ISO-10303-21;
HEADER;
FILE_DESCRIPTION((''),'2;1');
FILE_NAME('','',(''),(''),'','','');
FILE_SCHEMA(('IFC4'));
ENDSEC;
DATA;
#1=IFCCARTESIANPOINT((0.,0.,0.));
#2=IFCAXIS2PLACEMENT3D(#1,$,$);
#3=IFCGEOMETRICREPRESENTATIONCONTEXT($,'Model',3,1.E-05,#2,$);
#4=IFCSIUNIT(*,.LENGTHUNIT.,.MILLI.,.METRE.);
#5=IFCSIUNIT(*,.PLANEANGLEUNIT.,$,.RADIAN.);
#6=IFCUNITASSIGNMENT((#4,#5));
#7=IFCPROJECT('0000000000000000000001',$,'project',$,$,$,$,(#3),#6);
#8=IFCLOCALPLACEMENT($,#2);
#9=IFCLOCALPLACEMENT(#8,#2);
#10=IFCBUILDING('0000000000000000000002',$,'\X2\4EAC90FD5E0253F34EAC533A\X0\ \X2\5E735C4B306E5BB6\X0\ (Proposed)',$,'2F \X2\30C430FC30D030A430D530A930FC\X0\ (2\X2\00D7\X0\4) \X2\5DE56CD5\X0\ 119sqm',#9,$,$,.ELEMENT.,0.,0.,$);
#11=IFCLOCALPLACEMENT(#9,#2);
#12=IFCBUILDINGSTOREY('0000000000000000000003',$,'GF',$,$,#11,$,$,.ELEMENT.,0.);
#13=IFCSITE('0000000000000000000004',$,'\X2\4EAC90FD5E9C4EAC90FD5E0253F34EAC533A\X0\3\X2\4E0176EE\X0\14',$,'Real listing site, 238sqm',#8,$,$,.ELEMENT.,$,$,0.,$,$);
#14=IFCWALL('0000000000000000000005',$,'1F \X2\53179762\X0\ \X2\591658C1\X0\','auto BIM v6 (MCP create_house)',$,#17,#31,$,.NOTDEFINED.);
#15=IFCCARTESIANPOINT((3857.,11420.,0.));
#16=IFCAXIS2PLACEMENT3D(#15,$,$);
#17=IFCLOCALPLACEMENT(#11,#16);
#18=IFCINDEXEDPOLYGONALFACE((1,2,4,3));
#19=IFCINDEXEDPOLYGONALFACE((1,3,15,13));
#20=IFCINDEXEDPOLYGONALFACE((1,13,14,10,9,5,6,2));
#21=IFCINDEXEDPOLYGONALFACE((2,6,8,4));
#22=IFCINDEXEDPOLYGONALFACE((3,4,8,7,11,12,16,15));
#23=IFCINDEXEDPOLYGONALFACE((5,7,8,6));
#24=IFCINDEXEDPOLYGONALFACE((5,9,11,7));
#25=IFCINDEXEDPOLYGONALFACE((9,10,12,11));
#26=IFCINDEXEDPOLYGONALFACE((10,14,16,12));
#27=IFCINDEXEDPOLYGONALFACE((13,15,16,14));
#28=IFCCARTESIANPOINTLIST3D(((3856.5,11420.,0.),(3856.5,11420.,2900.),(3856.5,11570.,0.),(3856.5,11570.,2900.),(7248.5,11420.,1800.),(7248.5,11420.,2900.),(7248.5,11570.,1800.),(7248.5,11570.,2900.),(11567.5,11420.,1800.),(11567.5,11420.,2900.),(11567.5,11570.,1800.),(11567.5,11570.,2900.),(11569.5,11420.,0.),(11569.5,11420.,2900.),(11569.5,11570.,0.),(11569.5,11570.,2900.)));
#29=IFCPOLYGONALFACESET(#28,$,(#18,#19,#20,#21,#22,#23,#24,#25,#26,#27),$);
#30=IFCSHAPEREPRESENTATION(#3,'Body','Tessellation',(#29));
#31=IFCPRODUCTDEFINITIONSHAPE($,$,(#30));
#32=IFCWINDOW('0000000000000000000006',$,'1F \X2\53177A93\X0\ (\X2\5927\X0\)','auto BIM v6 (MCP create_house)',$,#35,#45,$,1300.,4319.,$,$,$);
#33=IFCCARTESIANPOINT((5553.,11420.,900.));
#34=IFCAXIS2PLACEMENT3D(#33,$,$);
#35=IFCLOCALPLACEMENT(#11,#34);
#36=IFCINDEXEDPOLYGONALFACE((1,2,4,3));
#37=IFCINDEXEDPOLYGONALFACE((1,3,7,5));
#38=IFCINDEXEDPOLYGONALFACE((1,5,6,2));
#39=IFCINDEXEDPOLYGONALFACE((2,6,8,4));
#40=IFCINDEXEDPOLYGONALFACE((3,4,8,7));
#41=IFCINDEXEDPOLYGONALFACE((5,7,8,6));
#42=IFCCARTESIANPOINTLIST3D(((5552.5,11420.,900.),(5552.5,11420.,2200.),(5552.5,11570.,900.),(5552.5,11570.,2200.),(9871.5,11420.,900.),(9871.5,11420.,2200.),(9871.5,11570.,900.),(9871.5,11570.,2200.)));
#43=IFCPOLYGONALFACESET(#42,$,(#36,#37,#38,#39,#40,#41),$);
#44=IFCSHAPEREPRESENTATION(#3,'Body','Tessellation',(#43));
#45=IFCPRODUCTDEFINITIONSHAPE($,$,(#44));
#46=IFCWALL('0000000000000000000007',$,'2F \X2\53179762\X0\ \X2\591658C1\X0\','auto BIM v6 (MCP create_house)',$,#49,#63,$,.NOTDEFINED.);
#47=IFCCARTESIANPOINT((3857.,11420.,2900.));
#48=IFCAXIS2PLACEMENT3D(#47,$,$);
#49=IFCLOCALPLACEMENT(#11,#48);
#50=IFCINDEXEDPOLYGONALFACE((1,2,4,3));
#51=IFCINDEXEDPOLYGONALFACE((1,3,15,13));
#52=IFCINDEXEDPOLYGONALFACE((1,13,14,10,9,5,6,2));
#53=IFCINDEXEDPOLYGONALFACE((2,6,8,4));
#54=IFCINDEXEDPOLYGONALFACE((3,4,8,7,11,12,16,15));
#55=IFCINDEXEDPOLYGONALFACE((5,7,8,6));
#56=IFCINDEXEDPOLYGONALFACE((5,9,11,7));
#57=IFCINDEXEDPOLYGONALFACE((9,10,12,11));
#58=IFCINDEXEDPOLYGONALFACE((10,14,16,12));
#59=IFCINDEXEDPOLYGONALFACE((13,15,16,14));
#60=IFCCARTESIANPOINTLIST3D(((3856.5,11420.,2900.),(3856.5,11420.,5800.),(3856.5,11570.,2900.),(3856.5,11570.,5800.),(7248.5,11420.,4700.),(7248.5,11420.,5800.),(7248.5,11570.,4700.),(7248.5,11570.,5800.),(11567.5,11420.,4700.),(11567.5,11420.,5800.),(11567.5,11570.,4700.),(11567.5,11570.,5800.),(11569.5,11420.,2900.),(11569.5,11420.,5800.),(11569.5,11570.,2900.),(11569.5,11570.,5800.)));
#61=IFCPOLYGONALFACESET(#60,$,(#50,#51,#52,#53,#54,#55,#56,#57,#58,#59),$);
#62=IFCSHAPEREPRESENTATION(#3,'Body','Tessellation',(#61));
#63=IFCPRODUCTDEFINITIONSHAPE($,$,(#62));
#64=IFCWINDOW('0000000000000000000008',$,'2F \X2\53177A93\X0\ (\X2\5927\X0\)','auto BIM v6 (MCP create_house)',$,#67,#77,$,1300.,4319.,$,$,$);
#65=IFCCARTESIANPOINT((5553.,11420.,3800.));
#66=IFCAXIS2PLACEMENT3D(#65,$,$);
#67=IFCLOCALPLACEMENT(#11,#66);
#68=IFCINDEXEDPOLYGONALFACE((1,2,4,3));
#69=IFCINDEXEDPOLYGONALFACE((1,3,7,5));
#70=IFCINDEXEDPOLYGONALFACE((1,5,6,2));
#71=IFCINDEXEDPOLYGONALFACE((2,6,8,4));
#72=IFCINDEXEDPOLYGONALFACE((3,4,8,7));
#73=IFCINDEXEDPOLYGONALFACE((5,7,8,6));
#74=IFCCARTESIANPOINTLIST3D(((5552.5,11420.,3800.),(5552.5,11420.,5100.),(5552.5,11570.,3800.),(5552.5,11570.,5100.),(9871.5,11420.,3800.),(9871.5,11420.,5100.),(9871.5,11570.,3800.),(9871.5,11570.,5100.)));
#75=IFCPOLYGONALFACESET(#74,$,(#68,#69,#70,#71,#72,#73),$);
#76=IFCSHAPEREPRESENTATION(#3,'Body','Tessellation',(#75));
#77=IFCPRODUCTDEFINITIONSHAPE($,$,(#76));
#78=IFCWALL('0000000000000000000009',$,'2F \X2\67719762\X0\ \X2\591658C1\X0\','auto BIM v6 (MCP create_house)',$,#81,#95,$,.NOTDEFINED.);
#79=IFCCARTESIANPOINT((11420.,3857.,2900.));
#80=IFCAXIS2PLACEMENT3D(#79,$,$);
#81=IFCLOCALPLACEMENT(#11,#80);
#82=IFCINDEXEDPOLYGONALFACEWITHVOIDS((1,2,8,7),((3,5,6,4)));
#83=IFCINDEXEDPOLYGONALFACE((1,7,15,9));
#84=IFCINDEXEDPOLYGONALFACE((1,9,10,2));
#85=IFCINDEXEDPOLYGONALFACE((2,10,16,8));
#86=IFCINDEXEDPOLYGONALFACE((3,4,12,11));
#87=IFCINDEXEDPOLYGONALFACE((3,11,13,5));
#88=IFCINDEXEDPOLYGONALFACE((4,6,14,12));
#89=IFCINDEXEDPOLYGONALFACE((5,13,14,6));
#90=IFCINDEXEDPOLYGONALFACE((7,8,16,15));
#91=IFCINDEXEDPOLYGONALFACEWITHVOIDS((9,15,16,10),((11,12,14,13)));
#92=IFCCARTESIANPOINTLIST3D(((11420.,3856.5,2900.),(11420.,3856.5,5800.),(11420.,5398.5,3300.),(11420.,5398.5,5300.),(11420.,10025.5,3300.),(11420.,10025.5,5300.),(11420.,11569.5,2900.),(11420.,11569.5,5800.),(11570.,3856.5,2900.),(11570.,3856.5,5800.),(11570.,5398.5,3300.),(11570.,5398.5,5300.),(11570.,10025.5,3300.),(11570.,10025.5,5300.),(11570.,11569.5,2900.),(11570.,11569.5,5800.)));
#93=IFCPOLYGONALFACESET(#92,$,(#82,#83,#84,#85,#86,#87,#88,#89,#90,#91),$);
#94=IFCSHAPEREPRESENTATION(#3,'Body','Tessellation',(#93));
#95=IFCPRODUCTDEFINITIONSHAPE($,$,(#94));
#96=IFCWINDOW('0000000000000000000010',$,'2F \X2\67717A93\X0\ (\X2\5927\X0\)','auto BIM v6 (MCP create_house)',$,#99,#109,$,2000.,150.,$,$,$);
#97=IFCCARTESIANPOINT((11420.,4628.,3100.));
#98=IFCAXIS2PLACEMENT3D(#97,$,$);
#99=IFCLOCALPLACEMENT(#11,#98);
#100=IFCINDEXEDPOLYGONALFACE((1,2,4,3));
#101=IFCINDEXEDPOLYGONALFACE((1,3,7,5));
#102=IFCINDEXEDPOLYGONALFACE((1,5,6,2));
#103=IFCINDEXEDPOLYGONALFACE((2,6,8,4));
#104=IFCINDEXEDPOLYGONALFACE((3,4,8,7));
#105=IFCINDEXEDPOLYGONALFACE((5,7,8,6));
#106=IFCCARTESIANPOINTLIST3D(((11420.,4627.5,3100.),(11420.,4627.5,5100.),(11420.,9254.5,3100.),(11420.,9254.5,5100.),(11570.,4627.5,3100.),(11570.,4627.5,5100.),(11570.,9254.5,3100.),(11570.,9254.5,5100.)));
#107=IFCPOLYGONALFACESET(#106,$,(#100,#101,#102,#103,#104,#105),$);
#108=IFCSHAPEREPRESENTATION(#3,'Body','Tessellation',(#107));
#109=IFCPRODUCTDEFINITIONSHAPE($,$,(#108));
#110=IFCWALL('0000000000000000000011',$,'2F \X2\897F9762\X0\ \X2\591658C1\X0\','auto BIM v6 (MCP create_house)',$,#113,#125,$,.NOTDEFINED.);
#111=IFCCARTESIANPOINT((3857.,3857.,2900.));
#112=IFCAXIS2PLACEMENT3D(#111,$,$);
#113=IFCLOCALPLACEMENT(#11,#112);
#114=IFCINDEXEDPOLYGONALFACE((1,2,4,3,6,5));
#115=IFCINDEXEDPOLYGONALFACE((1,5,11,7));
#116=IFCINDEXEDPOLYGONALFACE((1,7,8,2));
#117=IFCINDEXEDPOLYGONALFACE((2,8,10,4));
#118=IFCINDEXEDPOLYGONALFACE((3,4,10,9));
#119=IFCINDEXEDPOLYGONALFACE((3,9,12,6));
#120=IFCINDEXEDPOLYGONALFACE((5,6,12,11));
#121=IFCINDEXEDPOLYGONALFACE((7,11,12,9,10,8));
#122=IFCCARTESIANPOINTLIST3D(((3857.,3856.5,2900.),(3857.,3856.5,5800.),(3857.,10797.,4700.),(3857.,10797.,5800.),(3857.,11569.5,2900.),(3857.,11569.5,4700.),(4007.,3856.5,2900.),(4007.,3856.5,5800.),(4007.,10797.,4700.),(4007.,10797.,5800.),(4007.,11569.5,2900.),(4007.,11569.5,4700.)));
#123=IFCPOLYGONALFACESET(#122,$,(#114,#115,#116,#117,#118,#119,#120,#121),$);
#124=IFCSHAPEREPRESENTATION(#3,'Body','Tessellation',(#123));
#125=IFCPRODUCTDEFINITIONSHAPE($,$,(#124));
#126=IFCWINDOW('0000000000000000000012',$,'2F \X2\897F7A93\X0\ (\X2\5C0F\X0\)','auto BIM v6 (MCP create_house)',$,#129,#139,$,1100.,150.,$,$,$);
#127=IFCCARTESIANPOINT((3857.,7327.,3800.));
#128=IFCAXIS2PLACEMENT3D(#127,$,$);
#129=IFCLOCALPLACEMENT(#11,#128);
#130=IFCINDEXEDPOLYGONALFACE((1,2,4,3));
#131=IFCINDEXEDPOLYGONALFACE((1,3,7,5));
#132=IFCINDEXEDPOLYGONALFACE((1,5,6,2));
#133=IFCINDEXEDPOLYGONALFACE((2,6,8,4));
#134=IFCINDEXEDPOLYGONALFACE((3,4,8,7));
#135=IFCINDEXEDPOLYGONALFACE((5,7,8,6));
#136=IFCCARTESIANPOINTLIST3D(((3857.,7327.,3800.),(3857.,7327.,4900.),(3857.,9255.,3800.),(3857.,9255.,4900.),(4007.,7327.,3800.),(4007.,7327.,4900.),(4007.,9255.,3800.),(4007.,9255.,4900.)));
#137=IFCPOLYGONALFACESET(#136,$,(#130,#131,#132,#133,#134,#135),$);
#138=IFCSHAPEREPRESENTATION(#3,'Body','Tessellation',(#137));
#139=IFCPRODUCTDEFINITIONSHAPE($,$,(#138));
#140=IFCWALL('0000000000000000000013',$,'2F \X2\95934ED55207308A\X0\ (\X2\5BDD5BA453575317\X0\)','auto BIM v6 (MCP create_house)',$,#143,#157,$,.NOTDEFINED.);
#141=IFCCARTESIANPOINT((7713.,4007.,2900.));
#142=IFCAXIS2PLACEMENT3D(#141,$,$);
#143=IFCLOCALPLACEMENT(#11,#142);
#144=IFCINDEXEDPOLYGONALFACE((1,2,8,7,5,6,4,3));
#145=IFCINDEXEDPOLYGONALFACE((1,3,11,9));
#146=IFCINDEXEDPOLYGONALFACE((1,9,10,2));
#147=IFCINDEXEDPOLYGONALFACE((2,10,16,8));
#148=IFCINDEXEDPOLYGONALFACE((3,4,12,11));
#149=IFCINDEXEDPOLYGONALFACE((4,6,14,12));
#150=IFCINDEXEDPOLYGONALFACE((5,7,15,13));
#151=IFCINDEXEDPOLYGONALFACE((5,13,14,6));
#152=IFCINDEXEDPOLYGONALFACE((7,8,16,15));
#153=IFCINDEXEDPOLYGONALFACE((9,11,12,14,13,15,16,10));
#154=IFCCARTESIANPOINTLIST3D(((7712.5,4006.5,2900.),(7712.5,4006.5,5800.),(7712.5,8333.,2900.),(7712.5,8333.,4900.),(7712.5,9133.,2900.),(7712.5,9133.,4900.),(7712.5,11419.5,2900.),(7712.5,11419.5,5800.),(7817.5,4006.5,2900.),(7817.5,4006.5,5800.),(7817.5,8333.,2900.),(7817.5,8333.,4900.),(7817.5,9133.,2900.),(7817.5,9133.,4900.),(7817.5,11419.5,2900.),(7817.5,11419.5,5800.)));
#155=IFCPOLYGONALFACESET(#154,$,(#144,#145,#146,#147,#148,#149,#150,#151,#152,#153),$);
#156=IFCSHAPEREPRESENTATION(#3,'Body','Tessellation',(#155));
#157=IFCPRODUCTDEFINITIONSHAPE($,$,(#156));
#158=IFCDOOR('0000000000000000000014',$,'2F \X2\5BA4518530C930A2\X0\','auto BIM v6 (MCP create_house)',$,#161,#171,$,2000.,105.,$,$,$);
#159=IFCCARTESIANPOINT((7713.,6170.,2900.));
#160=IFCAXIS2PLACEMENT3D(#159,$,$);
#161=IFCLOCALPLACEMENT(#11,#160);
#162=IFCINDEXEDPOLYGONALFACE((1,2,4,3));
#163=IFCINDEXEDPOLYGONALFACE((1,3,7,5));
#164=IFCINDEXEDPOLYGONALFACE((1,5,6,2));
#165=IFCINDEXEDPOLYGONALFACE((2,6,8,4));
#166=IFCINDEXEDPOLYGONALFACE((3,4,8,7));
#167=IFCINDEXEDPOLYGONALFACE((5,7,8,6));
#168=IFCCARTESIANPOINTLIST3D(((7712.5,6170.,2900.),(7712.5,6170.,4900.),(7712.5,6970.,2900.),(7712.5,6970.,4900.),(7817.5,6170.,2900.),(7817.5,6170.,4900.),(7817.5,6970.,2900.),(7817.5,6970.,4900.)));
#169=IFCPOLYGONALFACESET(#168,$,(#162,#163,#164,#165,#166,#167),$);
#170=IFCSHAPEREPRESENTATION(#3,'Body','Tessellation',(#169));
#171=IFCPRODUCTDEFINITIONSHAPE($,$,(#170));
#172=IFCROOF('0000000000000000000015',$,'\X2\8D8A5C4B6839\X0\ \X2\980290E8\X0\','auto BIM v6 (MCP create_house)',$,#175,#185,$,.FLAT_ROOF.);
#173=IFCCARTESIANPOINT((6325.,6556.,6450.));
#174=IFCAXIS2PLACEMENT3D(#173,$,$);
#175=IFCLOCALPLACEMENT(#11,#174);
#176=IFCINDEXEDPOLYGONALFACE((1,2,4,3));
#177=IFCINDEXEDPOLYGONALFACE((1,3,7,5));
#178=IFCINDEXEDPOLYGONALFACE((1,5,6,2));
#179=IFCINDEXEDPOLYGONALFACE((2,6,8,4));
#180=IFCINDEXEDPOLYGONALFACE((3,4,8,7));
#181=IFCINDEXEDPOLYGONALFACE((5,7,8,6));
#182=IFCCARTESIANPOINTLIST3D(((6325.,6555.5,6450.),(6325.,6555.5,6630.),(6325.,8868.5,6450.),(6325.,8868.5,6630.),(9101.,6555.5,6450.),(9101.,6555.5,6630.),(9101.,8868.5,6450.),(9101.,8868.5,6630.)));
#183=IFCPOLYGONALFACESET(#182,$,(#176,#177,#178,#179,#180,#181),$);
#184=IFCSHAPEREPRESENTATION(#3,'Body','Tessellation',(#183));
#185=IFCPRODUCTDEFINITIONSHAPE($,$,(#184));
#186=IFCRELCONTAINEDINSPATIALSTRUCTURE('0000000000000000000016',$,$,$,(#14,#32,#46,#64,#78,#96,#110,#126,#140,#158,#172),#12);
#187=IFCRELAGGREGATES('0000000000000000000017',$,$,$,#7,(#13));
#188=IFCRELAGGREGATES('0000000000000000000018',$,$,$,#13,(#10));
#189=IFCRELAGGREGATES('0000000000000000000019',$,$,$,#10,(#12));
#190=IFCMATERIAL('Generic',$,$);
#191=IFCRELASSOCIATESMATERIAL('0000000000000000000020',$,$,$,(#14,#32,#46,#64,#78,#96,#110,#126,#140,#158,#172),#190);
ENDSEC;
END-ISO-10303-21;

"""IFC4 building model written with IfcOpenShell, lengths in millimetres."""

from ifc_helpers import new_model, si_unit, frame, frame_2d, origin, place, context, project, spatial, rectangle, extrude, material, element, fill, save


model = new_model("IFC4")

# Units and contexts
model_context = context("Model", 3, precision=1e-05, world=origin())
ifc_project = project(units=[si_unit("LENGTHUNIT", "METRE", prefix="MILLI"), si_unit("PLANEANGLEUNIT", "RADIAN")], contexts=[model_context])

# Site, building, storey
site_placement = place(None, origin())
site = spatial("IfcSite", under=ifc_project, at=site_placement, Name="京都府京都市右京区3丁目14", ObjectType="Real listing site, 238sqm", CompositionType="ELEMENT", RefElevation=0.0)
building_placement = place(site_placement, origin())
building = spatial("IfcBuilding", under=site, at=building_placement, Name="京都市右京区 平屋の家 (Proposed)", ObjectType="2F ツーバイフォー (2×4) 工法 119sqm", CompositionType="ELEMENT", ElevationOfRefHeight=0.0, ElevationOfTerrain=0.0)
storey_placement = place(building_placement, origin())
storey = spatial("IfcBuildingStorey", under=building, at=storey_placement, Name="GF", CompositionType="ELEMENT", Elevation=0.0)

# Wall, opening, window
ifc_material = material(Name="Generic")
wall_1_placement = place(storey_placement, frame((3857.0, 11420.0, 0.0)))
wall_1 = element("IfcWall", 1, at=wall_1_placement, inside=storey, material=ifc_material, Name="1F 北面 外壁", Description="auto BIM v6 (MCP create_house)", PredefinedType="NOTDEFINED", context=model_context, shape_type="SweptSolid", body=[
    extrude(rectangle(XDim=7713.0, YDim=150.0, at=frame_2d((3856.0, 75.0))), frame((3857.0, 11420.0, 0.0)), (0.0, 0.0, 1.0), 2900.0),
])
opening_1_placement = place(storey_placement, frame((5553.0, 11420.0, 900.0)))
opening_1 = element("IfcOpeningElement", 2, at=opening_1_placement, cuts=wall_1, PredefinedType="NOTDEFINED", context=model_context, shape_type="SweptSolid", body=[
    extrude(rectangle(XDim=4319.0, YDim=150.0, at=frame_2d((2159.0, 75.0))), frame((5553.0, 11420.0, 900.0)), (0.0, 0.0, 1.0), 1300.0),
])
window_1_placement = place(storey_placement, frame((5553.0, 11420.0, 900.0)))
window_1 = element("IfcWindow", 3, at=window_1_placement, inside=storey, material=ifc_material, Name="1F 北窓 (大)", Description="auto BIM v6 (MCP create_house)", OverallHeight=1300.0, OverallWidth=4319.0, context=model_context, shape_type="SweptSolid", body=[
    extrude(rectangle(XDim=4319.0, YDim=150.0, at=frame_2d((2159.0, 75.0))), frame((5553.0, 11420.0, 900.0)), (0.0, 0.0, 1.0), 1300.0),
])
fill(opening_1, window_1)

# Walls, openings, windows
wall_2_placement = place(storey_placement, frame((3857.0, 11420.0, 2900.0)))
wall_2 = element("IfcWall", 4, at=wall_2_placement, inside=storey, material=ifc_material, Name="2F 北面 外壁", Description="auto BIM v6 (MCP create_house)", PredefinedType="NOTDEFINED", context=model_context, shape_type="SweptSolid", body=[
    extrude(rectangle(XDim=7713.0, YDim=150.0, at=frame_2d((3856.0, 75.0))), frame((3857.0, 11420.0, 2900.0)), (0.0, 0.0, 1.0), 2900.0),
])
opening_2_placement = place(storey_placement, frame((5553.0, 11420.0, 3800.0)))
opening_2 = element("IfcOpeningElement", 5, at=opening_2_placement, cuts=wall_2, PredefinedType="NOTDEFINED", context=model_context, shape_type="SweptSolid", body=[
    extrude(rectangle(XDim=4319.0, YDim=150.0, at=frame_2d((2159.0, 75.0))), frame((5553.0, 11420.0, 3800.0)), (0.0, 0.0, 1.0), 1300.0),
])
window_2_placement = place(storey_placement, frame((5553.0, 11420.0, 3800.0)))
window_2 = element("IfcWindow", 6, at=window_2_placement, inside=storey, material=ifc_material, Name="2F 北窓 (大)", Description="auto BIM v6 (MCP create_house)", OverallHeight=1300.0, OverallWidth=4319.0, context=model_context, shape_type="SweptSolid", body=[
    extrude(rectangle(XDim=4319.0, YDim=150.0, at=frame_2d((2159.0, 75.0))), frame((5553.0, 11420.0, 3800.0)), (0.0, 0.0, 1.0), 1300.0),
])
fill(opening_2, window_2)
wall_3_placement = place(storey_placement, frame((11420.0, 3857.0, 2900.0)))
wall_3 = element("IfcWall", 7, at=wall_3_placement, inside=storey, material=ifc_material, Name="2F 東面 外壁", Description="auto BIM v6 (MCP create_house)", PredefinedType="NOTDEFINED", context=model_context, shape_type="SweptSolid", body=[
    extrude(rectangle(XDim=150.0, YDim=7713.0, at=frame_2d((75.0, 3856.0))), frame((11420.0, 3857.0, 2900.0)), (0.0, 0.0, 1.0), 2900.0),
])
opening_3_placement = place(storey_placement, frame((11420.0, 4628.0, 3100.0)))
opening_3 = element("IfcOpeningElement", 8, at=opening_3_placement, cuts=wall_3, PredefinedType="NOTDEFINED", context=model_context, shape_type="SweptSolid", body=[
    extrude(rectangle(XDim=150.0, YDim=4627.0, at=frame_2d((75.0, 2313.0))), frame((11420.0, 4628.0, 3100.0)), (0.0, 0.0, 1.0), 2000.0),
])
window_3_placement = place(storey_placement, frame((11420.0, 4628.0, 3100.0)))
window_3 = element("IfcWindow", 9, at=window_3_placement, inside=storey, material=ifc_material, Name="2F 東窓 (大)", Description="auto BIM v6 (MCP create_house)", OverallHeight=2000.0, OverallWidth=150.0, context=model_context, shape_type="SweptSolid", body=[
    extrude(rectangle(XDim=150.0, YDim=4627.0, at=frame_2d((75.0, 2313.0))), frame((11420.0, 4628.0, 3100.0)), (0.0, 0.0, 1.0), 2000.0),
])
fill(opening_3, window_3)
wall_4_placement = place(storey_placement, frame((3857.0, 3857.0, 2900.0)))
wall_4 = element("IfcWall", 10, at=wall_4_placement, inside=storey, material=ifc_material, Name="2F 西面 外壁", Description="auto BIM v6 (MCP create_house)", PredefinedType="NOTDEFINED", context=model_context, shape_type="SweptSolid", body=[
    extrude(rectangle(XDim=150.0, YDim=7713.0, at=frame_2d((75.0, 3856.0))), frame((3857.0, 3857.0, 2900.0)), (0.0, 0.0, 1.0), 2900.0),
])
opening_4_placement = place(storey_placement, frame((3857.0, 7327.0, 3800.0)))
opening_4 = element("IfcOpeningElement", 11, at=opening_4_placement, cuts=wall_4, PredefinedType="NOTDEFINED", context=model_context, shape_type="SweptSolid", body=[
    extrude(rectangle(XDim=150.0, YDim=1928.0, at=frame_2d((75.0, 964.0))), frame((3857.0, 7327.0, 3800.0)), (0.0, 0.0, 1.0), 1100.0),
])
window_4_placement = place(storey_placement, frame((3857.0, 7327.0, 3800.0)))
window_4 = element("IfcWindow", 12, at=window_4_placement, inside=storey, material=ifc_material, Name="2F 西窓 (小)", Description="auto BIM v6 (MCP create_house)", OverallHeight=1100.0, OverallWidth=150.0, context=model_context, shape_type="SweptSolid", body=[
    extrude(rectangle(XDim=150.0, YDim=1928.0, at=frame_2d((75.0, 964.0))), frame((3857.0, 7327.0, 3800.0)), (0.0, 0.0, 1.0), 1100.0),
])
fill(opening_4, window_4)

# Wall, opening, door
wall_5_placement = place(storey_placement, frame((7713.0, 4007.0, 2900.0)))
wall_5 = element("IfcWall", 13, at=wall_5_placement, inside=storey, material=ifc_material, Name="2F 間仕切り (寝室南北)", Description="auto BIM v6 (MCP create_house)", PredefinedType="NOTDEFINED", context=model_context, shape_type="SweptSolid", body=[
    extrude(rectangle(XDim=105.0, YDim=7413.0, at=frame_2d((52.0, 3706.0))), frame((7713.0, 4007.0, 2900.0)), (0.0, 0.0, 1.0), 2900.0),
])
opening_5_placement = place(storey_placement, frame((7713.0, 6170.0, 2900.0)))
opening_5 = element("IfcOpeningElement", 14, at=opening_5_placement, cuts=wall_5, PredefinedType="NOTDEFINED", context=model_context, shape_type="SweptSolid", body=[
    extrude(rectangle(XDim=105.0, YDim=800.0, at=frame_2d((52.0, 400.0))), frame((7713.0, 6170.0, 2900.0)), (0.0, 0.0, 1.0), 2000.0),
])
door_placement = place(storey_placement, frame((7713.0, 6170.0, 2900.0)))
door = element("IfcDoor", 15, at=door_placement, inside=storey, material=ifc_material, Name="2F 室内ドア", Description="auto BIM v6 (MCP create_house)", OverallHeight=2000.0, OverallWidth=105.0, context=model_context, shape_type="SweptSolid", body=[
    extrude(rectangle(XDim=105.0, YDim=800.0, at=frame_2d((52.0, 400.0))), frame((7713.0, 6170.0, 2900.0)), (0.0, 0.0, 1.0), 2000.0),
])
fill(opening_5, door)

# Roof
roof_placement = place(storey_placement, frame((6325.0, 6556.0, 6450.0)))
element("IfcRoof", 16, at=roof_placement, inside=storey, material=ifc_material, Name="越屋根 頂部", Description="auto BIM v6 (MCP create_house)", PredefinedType="FLAT_ROOF", context=model_context, shape_type="SweptSolid", body=[
    extrude(rectangle(XDim=2776.0, YDim=2313.0, at=frame_2d((1388.0, 1156.0))), frame((6325.0, 6556.0, 6450.0)), (0.0, 0.0, 1.0), 180.0),
])

save(model, "model.ifc")
